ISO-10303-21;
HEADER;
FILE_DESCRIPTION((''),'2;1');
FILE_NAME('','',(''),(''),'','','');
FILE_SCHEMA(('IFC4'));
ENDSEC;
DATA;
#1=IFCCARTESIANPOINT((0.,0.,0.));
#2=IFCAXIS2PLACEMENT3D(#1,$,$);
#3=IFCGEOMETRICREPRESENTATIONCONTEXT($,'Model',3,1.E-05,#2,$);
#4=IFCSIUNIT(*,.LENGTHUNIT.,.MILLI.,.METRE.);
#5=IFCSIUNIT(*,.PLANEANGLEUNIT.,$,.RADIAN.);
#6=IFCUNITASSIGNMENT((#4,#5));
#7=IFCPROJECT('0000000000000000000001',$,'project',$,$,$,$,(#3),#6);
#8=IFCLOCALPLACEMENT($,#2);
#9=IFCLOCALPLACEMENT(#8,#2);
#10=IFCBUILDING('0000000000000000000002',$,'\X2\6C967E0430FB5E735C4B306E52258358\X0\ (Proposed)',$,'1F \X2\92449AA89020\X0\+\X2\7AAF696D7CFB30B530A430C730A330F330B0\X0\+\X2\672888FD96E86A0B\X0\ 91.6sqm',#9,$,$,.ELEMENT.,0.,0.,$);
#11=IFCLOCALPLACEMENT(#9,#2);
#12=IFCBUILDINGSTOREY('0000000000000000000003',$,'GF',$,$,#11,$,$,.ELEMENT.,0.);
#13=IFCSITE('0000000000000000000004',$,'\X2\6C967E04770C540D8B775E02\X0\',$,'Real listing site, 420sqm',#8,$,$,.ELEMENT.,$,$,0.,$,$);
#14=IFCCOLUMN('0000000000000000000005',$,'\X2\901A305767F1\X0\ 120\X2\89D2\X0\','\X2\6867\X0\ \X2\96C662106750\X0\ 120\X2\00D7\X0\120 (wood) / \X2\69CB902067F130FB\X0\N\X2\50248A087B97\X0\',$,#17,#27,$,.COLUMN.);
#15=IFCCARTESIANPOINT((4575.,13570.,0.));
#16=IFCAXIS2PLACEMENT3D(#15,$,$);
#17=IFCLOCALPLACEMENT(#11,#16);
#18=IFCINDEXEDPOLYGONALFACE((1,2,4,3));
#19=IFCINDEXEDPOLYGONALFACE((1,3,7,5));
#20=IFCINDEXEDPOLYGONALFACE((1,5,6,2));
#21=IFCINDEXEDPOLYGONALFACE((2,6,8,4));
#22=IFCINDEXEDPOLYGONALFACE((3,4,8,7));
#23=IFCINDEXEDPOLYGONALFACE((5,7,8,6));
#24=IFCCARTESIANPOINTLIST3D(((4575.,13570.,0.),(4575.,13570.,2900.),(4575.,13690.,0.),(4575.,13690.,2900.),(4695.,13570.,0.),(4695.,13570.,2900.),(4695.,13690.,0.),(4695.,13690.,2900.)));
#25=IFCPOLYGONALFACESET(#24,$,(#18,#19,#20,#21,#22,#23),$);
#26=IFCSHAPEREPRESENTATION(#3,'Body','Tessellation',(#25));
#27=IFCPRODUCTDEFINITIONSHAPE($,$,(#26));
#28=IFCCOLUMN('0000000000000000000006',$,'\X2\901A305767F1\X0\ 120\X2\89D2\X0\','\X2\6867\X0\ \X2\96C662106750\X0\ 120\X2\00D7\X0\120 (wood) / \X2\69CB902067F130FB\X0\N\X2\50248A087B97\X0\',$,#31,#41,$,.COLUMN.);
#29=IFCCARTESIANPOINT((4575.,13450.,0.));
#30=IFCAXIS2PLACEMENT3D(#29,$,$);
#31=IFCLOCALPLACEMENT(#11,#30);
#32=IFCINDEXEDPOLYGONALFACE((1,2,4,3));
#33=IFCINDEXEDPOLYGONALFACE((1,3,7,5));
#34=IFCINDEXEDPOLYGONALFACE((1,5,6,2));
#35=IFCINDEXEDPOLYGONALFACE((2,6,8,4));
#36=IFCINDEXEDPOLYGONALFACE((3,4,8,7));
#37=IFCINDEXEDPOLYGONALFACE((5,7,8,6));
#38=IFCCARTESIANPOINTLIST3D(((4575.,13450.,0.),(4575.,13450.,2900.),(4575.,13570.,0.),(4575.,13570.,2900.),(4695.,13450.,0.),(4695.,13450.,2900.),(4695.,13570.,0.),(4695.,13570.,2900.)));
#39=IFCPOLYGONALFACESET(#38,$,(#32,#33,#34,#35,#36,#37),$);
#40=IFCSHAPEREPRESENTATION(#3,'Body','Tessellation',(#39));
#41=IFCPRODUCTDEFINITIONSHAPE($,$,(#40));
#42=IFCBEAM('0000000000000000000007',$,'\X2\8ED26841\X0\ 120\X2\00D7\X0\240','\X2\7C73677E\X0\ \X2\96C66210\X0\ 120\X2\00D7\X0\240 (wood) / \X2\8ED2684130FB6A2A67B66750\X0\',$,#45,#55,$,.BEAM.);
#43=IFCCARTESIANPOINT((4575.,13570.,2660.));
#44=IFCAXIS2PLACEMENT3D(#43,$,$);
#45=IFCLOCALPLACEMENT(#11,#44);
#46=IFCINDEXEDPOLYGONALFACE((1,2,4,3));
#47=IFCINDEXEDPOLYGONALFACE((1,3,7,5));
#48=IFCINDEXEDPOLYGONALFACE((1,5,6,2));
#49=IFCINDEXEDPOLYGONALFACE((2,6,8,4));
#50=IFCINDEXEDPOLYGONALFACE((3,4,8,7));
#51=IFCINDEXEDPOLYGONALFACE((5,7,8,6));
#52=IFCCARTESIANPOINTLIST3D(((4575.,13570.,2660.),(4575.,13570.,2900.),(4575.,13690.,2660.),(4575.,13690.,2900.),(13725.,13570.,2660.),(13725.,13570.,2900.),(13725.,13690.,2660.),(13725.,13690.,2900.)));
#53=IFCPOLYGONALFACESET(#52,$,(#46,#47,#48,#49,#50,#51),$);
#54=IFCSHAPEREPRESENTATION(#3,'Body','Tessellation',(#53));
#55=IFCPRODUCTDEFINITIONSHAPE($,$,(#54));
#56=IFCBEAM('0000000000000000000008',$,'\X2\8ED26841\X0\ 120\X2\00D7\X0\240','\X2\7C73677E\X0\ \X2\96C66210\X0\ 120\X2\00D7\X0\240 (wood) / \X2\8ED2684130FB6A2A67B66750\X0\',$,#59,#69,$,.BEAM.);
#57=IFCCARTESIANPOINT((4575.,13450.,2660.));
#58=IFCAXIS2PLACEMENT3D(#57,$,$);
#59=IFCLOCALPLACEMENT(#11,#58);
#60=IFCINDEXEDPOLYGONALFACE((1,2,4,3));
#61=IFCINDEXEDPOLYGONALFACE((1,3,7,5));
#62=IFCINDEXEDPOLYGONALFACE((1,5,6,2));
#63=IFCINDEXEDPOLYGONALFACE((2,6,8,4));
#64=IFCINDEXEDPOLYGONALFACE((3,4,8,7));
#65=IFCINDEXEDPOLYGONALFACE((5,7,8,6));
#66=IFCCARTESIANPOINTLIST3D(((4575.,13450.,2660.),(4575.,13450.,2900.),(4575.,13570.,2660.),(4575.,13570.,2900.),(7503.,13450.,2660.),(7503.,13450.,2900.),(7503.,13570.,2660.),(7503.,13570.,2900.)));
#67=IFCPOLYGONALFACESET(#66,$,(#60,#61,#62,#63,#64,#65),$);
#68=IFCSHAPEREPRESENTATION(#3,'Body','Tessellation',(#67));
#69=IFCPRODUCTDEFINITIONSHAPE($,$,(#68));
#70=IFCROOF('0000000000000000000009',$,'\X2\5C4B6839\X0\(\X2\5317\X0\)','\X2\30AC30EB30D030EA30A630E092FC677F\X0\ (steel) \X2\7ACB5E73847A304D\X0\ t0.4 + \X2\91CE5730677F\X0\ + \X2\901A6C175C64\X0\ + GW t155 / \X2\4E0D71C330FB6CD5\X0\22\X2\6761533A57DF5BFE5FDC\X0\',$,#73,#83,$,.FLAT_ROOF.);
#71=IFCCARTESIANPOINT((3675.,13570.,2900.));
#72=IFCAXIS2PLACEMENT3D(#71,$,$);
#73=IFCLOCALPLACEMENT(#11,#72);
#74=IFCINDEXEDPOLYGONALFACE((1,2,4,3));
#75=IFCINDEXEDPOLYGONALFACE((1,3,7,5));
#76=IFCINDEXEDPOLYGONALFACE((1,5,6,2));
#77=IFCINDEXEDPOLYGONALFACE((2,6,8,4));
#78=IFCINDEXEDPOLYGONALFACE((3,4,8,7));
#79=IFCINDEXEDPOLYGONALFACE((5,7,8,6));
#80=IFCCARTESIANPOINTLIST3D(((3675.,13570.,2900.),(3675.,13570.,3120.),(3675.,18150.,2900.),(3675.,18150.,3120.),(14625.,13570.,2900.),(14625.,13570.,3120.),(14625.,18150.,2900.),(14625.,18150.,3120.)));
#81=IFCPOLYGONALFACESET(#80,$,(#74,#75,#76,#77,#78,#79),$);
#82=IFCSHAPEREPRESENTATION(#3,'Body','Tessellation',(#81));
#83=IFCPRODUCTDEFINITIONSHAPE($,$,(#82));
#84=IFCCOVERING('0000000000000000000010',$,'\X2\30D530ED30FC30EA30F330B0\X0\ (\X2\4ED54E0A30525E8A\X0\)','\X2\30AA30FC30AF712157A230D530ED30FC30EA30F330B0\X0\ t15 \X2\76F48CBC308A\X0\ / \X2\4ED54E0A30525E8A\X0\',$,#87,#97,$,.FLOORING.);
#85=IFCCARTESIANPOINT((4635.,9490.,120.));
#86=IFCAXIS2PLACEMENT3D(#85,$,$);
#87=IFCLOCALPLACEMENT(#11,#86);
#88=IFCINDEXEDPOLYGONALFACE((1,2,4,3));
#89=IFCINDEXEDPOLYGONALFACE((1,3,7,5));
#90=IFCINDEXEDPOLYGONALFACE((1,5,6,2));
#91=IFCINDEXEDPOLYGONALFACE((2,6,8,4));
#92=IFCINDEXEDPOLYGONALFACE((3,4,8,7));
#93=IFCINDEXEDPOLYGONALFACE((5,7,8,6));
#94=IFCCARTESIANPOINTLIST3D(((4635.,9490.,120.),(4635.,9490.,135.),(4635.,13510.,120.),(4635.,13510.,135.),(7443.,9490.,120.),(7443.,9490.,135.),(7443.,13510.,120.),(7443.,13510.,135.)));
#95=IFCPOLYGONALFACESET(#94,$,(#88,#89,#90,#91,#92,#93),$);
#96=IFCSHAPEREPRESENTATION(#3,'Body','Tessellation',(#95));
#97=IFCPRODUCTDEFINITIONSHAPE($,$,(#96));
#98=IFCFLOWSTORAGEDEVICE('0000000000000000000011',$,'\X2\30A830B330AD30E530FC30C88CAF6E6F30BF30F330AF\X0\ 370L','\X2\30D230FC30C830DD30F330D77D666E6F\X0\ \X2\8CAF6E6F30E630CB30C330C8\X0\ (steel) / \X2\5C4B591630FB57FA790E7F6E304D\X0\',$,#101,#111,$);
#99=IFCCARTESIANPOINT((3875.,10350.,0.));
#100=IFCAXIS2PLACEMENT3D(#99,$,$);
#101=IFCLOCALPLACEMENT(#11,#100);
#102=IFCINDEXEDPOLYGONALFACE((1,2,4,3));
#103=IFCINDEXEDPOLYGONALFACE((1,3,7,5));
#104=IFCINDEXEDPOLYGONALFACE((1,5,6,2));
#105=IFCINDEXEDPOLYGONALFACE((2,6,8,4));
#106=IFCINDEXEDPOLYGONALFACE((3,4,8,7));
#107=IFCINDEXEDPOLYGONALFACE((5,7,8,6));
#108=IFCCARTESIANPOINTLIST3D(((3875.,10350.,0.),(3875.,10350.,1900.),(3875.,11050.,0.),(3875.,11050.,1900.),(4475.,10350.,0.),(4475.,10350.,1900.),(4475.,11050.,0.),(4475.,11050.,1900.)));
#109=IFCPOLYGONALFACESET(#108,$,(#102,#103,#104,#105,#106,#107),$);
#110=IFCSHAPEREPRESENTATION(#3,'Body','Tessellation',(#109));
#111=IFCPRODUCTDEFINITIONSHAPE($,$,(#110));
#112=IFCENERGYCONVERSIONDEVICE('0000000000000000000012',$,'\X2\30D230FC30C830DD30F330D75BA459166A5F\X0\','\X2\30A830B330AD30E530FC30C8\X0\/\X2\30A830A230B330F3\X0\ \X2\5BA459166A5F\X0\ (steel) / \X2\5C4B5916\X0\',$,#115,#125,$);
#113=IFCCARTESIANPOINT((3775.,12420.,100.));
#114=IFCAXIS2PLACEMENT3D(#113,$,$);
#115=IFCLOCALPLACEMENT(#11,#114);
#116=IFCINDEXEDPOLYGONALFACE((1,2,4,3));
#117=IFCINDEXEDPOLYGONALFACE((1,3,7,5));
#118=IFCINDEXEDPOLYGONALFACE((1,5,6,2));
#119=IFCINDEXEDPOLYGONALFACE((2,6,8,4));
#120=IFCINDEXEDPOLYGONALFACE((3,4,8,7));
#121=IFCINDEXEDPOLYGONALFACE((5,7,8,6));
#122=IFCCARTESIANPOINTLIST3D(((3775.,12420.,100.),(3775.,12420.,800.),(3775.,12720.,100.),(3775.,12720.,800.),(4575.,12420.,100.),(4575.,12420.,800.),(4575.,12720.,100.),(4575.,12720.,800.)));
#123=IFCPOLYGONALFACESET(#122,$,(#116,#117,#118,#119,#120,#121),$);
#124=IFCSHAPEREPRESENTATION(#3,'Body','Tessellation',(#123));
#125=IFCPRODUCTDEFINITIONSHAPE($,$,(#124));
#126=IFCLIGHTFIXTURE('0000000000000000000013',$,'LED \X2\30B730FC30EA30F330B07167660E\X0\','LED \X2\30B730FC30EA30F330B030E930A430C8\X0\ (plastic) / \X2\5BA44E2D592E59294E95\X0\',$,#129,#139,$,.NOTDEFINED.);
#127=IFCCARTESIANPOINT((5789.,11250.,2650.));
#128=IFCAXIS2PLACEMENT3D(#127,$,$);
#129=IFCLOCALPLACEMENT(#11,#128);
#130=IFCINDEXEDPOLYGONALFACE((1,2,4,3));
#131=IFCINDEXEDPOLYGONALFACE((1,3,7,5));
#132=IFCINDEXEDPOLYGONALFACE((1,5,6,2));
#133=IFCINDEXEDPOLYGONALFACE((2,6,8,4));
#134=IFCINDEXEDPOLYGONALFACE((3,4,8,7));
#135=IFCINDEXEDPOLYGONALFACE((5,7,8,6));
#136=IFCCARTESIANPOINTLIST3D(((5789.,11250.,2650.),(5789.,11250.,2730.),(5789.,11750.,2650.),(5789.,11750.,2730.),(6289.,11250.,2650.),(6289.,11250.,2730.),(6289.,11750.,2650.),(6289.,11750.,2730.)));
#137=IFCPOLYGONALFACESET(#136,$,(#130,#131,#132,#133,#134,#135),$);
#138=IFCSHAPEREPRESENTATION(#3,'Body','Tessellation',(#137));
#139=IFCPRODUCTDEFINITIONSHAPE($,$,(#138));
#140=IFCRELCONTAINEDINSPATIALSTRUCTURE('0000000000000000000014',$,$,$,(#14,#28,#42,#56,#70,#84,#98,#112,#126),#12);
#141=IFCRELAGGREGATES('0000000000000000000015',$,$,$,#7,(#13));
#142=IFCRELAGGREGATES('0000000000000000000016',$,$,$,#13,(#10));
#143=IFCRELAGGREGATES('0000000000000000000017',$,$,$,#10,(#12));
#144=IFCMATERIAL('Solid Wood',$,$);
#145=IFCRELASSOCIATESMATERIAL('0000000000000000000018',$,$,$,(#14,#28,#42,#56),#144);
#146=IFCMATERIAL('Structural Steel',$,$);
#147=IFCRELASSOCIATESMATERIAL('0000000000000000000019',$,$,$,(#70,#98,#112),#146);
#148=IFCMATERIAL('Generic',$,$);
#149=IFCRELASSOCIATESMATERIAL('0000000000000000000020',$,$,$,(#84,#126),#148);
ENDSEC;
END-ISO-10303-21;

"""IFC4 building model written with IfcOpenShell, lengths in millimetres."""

from ifc_helpers import new_model, si_unit, frame, frame_2d, origin, place, context, project, spatial, rectangle, extrude, material, element, save


model = new_model("IFC4")

# Units and contexts
model_context = context("Model", 3, precision=1e-05, world=origin())
ifc_project = project(units=[si_unit("LENGTHUNIT", "METRE", prefix="MILLI"), si_unit("PLANEANGLEUNIT", "RADIAN")], contexts=[model_context])

# Site, building, storey
site_placement = place(None, origin())
site = spatial("IfcSite", under=ifc_project, at=site_placement, Name="沖縄県名護市", ObjectType="Real listing site, 420sqm", CompositionType="ELEMENT", RefElevation=0.0)
building_placement = place(site_placement, origin())
building = spatial("IfcBuilding", under=site, at=building_placement, Name="沖縄・平屋の別荘 (Proposed)", ObjectType="1F 鉄骨造+窯業系サイディング+木製雨樋 91.6sqm", CompositionType="ELEMENT", ElevationOfRefHeight=0.0, ElevationOfTerrain=0.0)
storey_placement = place(building_placement, origin())
storey = spatial("IfcBuildingStorey", under=building, at=storey_placement, Name="GF", CompositionType="ELEMENT", Elevation=0.0)

# Columns
ifc_material_1 = material(Name="Solid Wood")
column_1_placement = place(storey_placement, frame((4575.0, 13570.0, 0.0)))
element("IfcColumn", 1, at=column_1_placement, inside=storey, material=ifc_material_1, Name="通し柱 120角", Description="桧 集成材 120×120 (wood) / 構造柱・N値計算", PredefinedType="COLUMN", context=model_context, shape_type="SweptSolid", body=[
    extrude(rectangle(XDim=120.0, YDim=120.0, at=frame_2d((60.0, 60.0))), frame((4575.0, 13570.0, 0.0)), (0.0, 0.0, 1.0), 2900.0),
])
column_2_placement = place(storey_placement, frame((4575.0, 13450.0, 0.0)))
element("IfcColumn", 2, at=column_2_placement, inside=storey, material=ifc_material_1, Name="通し柱 120角", Description="桧 集成材 120×120 (wood) / 構造柱・N値計算", PredefinedType="COLUMN", context=model_context, shape_type="SweptSolid", body=[
    extrude(rectangle(XDim=120.0, YDim=120.0, at=frame_2d((60.0, 60.0))), frame((4575.0, 13450.0, 0.0)), (0.0, 0.0, 1.0), 2900.0),
])

# Beams
beam_1_placement = place(storey_placement, frame((4575.0, 13570.0, 2660.0)))
element("IfcBeam", 3, at=beam_1_placement, inside=storey, material=ifc_material_1, Name="軒桁 120×240", Description="米松 集成 120×240 (wood) / 軒桁・横架材", PredefinedType="BEAM", context=model_context, shape_type="SweptSolid", body=[
    extrude(rectangle(XDim=9150.0, YDim=120.0, at=frame_2d((4575.0, 60.0))), frame((4575.0, 13570.0, 2660.0)), (0.0, 0.0, 1.0), 240.0),
])
beam_2_placement = place(storey_placement, frame((4575.0, 13450.0, 2660.0)))
element("IfcBeam", 4, at=beam_2_placement, inside=storey, material=ifc_material_1, Name="軒桁 120×240", Description="米松 集成 120×240 (wood) / 軒桁・横架材", PredefinedType="BEAM", context=model_context, shape_type="SweptSolid", body=[
    extrude(rectangle(XDim=2928.0, YDim=120.0, at=frame_2d((1464.0, 60.0))), frame((4575.0, 13450.0, 2660.0)), (0.0, 0.0, 1.0), 240.0),
])

# Roof
ifc_material_2 = material(Name="Structural Steel")
roof_placement = place(storey_placement, frame((3675.0, 13570.0, 2900.0)))
element("IfcRoof", 5, at=roof_placement, inside=storey, material=ifc_material_2, Name="屋根(北)", Description="ガルバリウム鋼板 (steel) 立平葺き t0.4 + 野地板 + 通気層 + GW t155 / 不燃・法22条区域対応", PredefinedType="FLAT_ROOF", context=model_context, shape_type="SweptSolid", body=[
    extrude(rectangle(XDim=10950.0, YDim=4580.0, at=frame_2d((5475.0, 2290.0))), frame((3675.0, 13570.0, 2900.0)), (0.0, 0.0, 1.0), 220.0),
])

# Covering
ifc_material_3 = material(Name="Generic")
covering_placement = place(storey_placement, frame((4635.0, 9490.0, 120.0)))
element("IfcCovering", 6, at=covering_placement, inside=storey, material=ifc_material_3, Name="フローリング (仕上げ床)", Description="オーク無垢フローリング t15 直貼り / 仕上げ床", PredefinedType="FLOORING", context=model_context, shape_type="SweptSolid", body=[
    extrude(rectangle(XDim=2808.0, YDim=4020.0, at=frame_2d((1404.0, 2010.0))), frame((4635.0, 9490.0, 120.0)), (0.0, 0.0, 1.0), 15.0),
])

# Flow storage device
flow_storage_device_placement = place(storey_placement, frame((3875.0, 10350.0, 0.0)))
element("IfcFlowStorageDevice", 7, at=flow_storage_device_placement, inside=storey, material=ifc_material_2, Name="エコキュート貯湯タンク 370L", Description="ヒートポンプ給湯 貯湯ユニット (steel) / 屋外・基礎置き", context=model_context, shape_type="SweptSolid", body=[
    extrude(rectangle(XDim=600.0, YDim=700.0, at=frame_2d((300.0, 350.0))), frame((3875.0, 10350.0, 0.0)), (0.0, 0.0, 1.0), 1900.0),
])

# Energy conversion device
energy_conversion_device_placement = place(storey_placement, frame((3775.0, 12420.0, 100.0)))
element("IfcEnergyConversionDevice", 8, at=energy_conversion_device_placement, inside=storey, material=ifc_material_2, Name="ヒートポンプ室外機", Description="エコキュート/エアコン 室外機 (steel) / 屋外", context=model_context, shape_type="SweptSolid", body=[
    extrude(rectangle(XDim=800.0, YDim=300.0, at=frame_2d((400.0, 150.0))), frame((3775.0, 12420.0, 100.0)), (0.0, 0.0, 1.0), 700.0),
])

# Light fixture
light_fixture_placement = place(storey_placement, frame((5789.0, 11250.0, 2650.0)))
element("IfcLightFixture", 9, at=light_fixture_placement, inside=storey, material=ifc_material_3, Name="LED シーリング照明", Description="LED シーリングライト (plastic) / 室中央天井", PredefinedType="NOTDEFINED", context=model_context, shape_type="SweptSolid", body=[
    extrude(rectangle(XDim=500.0, YDim=500.0, at=frame_2d((250.0, 250.0))), frame((5789.0, 11250.0, 2650.0)), (0.0, 0.0, 1.0), 80.0),
])

save(model, "model.ifc")
